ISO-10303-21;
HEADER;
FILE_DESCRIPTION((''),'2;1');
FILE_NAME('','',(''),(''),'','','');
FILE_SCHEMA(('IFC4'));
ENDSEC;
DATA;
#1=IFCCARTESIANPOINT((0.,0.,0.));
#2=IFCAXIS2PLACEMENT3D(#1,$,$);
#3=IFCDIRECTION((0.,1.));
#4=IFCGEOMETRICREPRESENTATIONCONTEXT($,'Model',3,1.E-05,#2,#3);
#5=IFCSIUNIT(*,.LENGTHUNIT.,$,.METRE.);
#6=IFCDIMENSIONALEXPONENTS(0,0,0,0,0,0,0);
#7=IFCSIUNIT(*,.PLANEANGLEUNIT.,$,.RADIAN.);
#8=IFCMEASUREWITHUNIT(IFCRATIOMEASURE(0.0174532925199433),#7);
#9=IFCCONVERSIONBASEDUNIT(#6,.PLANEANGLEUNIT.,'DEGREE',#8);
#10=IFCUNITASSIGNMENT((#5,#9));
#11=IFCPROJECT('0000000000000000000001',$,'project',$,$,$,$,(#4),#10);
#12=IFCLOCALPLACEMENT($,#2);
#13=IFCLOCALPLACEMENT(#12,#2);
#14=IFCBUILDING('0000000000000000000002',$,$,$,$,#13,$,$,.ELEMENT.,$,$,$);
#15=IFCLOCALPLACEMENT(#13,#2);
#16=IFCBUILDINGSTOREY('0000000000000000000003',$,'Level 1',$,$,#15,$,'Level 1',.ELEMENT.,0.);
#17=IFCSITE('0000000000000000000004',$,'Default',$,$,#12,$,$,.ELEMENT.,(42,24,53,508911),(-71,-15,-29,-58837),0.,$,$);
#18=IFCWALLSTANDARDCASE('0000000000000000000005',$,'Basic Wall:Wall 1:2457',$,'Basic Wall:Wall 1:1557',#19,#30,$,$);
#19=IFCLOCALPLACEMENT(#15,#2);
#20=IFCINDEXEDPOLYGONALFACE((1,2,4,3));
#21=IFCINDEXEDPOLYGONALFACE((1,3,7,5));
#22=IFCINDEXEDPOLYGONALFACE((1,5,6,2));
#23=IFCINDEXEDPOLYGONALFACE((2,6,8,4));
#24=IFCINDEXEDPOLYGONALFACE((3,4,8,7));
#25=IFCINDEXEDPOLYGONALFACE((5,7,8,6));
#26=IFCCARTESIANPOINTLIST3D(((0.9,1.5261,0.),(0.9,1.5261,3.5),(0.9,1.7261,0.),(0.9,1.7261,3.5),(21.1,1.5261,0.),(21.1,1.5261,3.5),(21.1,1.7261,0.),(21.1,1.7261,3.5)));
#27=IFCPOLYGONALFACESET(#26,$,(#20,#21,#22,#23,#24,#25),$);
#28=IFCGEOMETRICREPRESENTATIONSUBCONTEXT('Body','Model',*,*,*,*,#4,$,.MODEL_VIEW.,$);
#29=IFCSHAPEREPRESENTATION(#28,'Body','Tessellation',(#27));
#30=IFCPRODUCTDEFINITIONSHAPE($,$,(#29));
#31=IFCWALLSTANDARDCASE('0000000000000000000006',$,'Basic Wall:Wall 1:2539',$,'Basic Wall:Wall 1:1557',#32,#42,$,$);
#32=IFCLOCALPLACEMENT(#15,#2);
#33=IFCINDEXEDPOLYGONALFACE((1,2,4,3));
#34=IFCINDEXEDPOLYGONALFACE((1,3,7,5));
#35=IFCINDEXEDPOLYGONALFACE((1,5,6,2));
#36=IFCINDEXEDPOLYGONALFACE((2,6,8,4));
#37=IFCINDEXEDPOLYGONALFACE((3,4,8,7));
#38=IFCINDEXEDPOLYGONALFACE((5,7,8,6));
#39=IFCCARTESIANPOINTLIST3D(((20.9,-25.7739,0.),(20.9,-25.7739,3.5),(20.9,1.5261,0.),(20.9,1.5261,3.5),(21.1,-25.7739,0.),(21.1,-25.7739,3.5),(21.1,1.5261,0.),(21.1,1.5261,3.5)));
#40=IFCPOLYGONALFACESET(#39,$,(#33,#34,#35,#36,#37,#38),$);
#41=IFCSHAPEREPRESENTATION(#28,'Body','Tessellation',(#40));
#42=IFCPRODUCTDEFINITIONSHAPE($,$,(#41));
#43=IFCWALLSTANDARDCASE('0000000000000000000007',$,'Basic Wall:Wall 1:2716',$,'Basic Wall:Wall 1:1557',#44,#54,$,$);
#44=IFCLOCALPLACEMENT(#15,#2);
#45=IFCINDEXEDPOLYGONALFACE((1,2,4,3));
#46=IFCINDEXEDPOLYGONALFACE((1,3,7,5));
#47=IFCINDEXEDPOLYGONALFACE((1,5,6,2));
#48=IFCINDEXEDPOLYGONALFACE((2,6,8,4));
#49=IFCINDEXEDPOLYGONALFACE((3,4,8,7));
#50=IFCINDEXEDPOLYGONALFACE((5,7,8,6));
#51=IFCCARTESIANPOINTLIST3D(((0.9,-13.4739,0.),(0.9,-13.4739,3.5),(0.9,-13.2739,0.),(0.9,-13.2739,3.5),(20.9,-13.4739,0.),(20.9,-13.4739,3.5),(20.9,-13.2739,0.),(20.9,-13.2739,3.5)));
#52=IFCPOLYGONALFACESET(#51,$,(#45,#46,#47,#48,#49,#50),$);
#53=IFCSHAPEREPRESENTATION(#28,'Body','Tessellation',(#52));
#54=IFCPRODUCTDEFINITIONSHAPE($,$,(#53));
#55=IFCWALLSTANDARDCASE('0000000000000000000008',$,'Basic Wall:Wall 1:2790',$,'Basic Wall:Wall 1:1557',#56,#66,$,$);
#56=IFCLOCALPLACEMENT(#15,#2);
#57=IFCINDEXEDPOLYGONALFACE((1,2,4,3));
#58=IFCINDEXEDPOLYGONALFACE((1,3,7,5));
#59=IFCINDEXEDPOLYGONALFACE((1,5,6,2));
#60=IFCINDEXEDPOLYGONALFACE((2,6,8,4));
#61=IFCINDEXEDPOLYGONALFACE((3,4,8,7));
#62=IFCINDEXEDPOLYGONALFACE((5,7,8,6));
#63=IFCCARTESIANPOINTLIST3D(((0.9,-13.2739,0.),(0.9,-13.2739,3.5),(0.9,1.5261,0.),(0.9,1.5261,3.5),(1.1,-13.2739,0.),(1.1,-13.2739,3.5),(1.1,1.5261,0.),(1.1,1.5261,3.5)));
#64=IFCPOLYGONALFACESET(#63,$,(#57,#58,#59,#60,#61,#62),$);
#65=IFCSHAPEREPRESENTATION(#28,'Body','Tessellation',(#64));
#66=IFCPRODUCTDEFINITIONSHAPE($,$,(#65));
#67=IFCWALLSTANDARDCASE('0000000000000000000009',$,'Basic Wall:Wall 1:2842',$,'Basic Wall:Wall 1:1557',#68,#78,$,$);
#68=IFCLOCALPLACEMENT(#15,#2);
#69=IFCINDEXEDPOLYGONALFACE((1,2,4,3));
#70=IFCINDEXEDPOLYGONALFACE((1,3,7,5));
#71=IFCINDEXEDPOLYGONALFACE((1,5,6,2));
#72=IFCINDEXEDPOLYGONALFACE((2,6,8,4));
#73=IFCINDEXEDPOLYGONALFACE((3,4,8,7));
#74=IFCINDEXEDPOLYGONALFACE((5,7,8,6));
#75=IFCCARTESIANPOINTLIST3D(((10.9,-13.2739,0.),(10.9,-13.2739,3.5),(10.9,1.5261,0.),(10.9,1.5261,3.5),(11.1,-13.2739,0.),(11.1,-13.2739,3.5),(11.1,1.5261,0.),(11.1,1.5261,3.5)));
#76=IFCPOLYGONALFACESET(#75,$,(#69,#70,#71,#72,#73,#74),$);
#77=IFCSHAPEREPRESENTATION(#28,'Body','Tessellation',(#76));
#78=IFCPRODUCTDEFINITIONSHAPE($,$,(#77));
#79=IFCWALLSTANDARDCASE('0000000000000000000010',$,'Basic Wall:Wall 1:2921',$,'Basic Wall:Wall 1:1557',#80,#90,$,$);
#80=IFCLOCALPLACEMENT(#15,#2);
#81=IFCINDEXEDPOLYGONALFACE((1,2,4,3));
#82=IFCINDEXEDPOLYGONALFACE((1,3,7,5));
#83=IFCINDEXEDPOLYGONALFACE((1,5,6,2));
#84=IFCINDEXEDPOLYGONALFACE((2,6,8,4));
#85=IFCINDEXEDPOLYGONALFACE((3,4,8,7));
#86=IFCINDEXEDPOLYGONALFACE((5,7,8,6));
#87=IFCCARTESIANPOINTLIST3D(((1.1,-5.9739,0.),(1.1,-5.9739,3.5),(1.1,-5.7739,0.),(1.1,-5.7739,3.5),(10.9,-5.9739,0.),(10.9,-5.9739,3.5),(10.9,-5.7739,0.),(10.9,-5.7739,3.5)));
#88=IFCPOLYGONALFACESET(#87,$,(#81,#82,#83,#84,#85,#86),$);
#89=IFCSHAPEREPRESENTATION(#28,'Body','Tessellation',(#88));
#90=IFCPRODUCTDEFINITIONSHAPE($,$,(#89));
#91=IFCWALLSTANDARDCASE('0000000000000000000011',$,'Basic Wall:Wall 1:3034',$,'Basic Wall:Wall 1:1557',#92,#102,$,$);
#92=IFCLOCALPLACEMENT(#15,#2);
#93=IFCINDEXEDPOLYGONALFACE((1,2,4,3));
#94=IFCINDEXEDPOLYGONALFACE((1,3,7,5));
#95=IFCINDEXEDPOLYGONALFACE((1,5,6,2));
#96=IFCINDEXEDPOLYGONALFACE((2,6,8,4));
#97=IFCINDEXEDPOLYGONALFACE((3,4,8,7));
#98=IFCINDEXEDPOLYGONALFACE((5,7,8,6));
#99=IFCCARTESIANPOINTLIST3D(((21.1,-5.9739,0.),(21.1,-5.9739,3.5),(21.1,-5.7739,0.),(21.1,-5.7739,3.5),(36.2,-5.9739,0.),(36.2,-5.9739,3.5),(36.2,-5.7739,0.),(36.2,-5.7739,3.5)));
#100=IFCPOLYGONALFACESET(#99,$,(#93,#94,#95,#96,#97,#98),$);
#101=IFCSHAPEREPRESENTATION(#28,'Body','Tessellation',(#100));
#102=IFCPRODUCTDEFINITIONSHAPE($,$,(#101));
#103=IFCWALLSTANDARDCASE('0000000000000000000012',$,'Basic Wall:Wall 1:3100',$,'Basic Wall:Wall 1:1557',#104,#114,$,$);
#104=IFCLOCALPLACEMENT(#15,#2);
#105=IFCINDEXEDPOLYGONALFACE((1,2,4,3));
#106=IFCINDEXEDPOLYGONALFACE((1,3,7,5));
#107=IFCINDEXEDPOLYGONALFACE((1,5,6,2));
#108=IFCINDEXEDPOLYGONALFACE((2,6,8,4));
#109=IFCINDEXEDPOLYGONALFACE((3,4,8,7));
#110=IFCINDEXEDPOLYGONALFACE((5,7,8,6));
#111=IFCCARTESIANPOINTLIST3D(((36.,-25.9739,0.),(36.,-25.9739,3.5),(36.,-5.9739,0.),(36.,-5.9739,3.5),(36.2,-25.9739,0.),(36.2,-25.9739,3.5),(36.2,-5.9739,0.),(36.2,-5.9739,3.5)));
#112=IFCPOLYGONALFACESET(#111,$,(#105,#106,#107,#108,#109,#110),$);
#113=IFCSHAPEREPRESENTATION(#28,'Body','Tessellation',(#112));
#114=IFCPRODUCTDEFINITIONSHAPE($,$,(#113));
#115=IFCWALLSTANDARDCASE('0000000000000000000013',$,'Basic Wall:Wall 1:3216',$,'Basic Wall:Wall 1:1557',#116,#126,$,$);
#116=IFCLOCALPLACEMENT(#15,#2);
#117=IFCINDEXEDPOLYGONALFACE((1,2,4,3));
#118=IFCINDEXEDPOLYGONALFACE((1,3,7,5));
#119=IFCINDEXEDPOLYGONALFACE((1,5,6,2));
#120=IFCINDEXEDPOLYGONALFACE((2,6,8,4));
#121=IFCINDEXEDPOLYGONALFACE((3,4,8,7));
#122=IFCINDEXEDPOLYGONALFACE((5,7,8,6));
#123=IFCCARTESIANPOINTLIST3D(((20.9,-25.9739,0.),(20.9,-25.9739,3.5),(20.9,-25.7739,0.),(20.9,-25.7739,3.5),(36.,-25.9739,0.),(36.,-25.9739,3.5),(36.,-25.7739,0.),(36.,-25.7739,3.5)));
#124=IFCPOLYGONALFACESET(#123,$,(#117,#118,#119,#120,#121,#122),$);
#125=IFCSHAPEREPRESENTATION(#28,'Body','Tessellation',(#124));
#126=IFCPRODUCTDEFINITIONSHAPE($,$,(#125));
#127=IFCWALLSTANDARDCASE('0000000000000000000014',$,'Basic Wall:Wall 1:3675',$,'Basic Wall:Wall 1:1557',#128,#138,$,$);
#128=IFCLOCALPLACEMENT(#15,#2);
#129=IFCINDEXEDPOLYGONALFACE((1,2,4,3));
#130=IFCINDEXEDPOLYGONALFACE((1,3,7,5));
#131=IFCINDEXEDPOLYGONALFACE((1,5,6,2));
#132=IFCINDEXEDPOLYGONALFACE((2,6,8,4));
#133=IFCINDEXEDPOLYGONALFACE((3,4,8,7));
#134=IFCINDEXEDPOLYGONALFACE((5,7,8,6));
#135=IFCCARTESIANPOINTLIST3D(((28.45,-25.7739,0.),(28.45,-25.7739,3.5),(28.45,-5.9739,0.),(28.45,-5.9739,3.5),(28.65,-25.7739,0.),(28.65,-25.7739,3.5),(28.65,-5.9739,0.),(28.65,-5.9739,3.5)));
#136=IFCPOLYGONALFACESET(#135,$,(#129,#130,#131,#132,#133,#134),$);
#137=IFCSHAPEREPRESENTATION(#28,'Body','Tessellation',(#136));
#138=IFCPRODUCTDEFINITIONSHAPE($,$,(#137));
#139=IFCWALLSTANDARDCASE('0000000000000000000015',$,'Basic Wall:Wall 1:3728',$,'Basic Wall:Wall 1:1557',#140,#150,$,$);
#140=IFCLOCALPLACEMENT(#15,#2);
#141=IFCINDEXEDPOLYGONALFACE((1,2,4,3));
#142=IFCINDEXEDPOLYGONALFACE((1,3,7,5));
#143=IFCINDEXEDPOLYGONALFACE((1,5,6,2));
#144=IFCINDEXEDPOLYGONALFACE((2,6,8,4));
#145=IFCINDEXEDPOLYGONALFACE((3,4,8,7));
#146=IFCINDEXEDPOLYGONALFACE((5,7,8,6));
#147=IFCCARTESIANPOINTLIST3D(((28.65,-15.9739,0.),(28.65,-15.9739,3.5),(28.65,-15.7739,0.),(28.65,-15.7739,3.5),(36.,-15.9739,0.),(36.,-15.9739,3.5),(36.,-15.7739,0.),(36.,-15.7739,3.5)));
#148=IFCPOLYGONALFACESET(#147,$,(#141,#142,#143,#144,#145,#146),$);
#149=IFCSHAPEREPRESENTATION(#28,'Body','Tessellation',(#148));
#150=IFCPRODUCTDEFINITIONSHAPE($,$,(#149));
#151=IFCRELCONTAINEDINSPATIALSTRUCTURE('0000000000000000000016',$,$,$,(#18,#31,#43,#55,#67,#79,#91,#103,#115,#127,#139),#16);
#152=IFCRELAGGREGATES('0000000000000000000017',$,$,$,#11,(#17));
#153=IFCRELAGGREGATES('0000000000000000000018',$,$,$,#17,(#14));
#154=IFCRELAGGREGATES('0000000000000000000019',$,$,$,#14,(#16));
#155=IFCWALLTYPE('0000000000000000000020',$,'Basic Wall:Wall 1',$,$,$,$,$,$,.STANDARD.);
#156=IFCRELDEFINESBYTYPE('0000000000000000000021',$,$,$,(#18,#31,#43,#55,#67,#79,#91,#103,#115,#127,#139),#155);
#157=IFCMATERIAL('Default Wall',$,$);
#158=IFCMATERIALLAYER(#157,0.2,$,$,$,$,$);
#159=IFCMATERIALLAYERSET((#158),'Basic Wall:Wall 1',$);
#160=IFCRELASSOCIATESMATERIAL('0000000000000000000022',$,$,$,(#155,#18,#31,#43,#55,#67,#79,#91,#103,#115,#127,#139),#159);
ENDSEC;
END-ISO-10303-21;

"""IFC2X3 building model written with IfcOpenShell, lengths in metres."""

from ifc_helpers import new_model, entity, si_unit, converted_unit, direction, frame, frame_2d, origin, place, context, subcontext, project, spatial, rectangle, extrude, material, layer, layer_set, layer_usage, type_object, element, save


model = new_model("IFC2X3")

# Units and contexts
model_context = context("Model", 3, precision=1e-05, world=origin(), true_north=direction((0.0, 1.0)))
body_context = subcontext(model_context, "Body", "Model", "MODEL_VIEW")
ifc_project = project(units=[si_unit("LENGTHUNIT", "METRE"), converted_unit("PLANEANGLEUNIT", "DEGREE", entity("IfcRatioMeasure", 0.0174532925199433), si_unit("PLANEANGLEUNIT", "RADIAN"), dimensions=[0, 0, 0, 0, 0, 0, 0])], contexts=[model_context])

# Site, building, storey
site_placement = place(None, origin())
site = spatial("IfcSite", under=ifc_project, at=site_placement, Name="Default", CompositionType="ELEMENT", RefLatitude=(42, 24, 53, 508911), RefLongitude=(-71, -15, -29, -58837), RefElevation=0.0)
building_placement = place(site_placement, origin())
building = spatial("IfcBuilding", under=site, at=building_placement, CompositionType="ELEMENT")
storey_placement = place(building_placement, origin())
storey = spatial("IfcBuildingStorey", under=building, at=storey_placement, Name="Level 1", LongName="Level 1", CompositionType="ELEMENT", Elevation=0.0)

# Walls
ifc_material = material(Name="Default Wall")
ifc_layer = layer(ifc_material, 0.2)
ifc_layer_set = layer_set([ifc_layer], Name="Basic Wall:Wall 1")
ifc_layer_usage_1 = layer_usage(ifc_layer_set, "AXIS2", "NEGATIVE", 0.1)
wall_type = type_object("IfcWallType", Name="Basic Wall:Wall 1", PredefinedType="STANDARD", material=ifc_layer_set)
wall_1_placement = place(storey_placement, frame((0.9, 1.6261, 0.0)))
element("IfcWallStandardCase", 1, at=wall_1_placement, inside=storey, type_object=wall_type, material=ifc_layer_usage_1, Name="Basic Wall:Wall 1:2457", ObjectType="Basic Wall:Wall 1:1557", context=body_context, shape_type="SweptSolid", body=[
    extrude(rectangle(XDim=20.2, YDim=0.2, at=frame_2d((10.1, 0.0), x_axis=(-1.0, 0.0))), origin(), (0.0, 0.0, 1.0), 3.5),
])
ifc_layer_usage_2 = layer_usage(ifc_layer_set, "AXIS2", "NEGATIVE", 0.1)
wall_2_placement = place(storey_placement, frame((21.0, 1.5261, 0.0), z_axis=(0.0, 0.0, 1.0), x_axis=(0.0, -1.0, 0.0)))
element("IfcWallStandardCase", 2, at=wall_2_placement, inside=storey, type_object=wall_type, material=ifc_layer_usage_2, Name="Basic Wall:Wall 1:2539", ObjectType="Basic Wall:Wall 1:1557", context=body_context, shape_type="SweptSolid", body=[
    extrude(rectangle(XDim=27.3, YDim=0.2, at=frame_2d((13.65, 0.0), x_axis=(-1.0, 0.0))), origin(), (0.0, 0.0, 1.0), 3.5),
])
ifc_layer_usage_3 = layer_usage(ifc_layer_set, "AXIS2", "NEGATIVE", 0.1)
wall_3_placement = place(storey_placement, frame((20.9, -13.3739, 0.0), z_axis=(0.0, 0.0, 1.0), x_axis=(-1.0, 0.0, 0.0)))
element("IfcWallStandardCase", 3, at=wall_3_placement, inside=storey, type_object=wall_type, material=ifc_layer_usage_3, Name="Basic Wall:Wall 1:2716", ObjectType="Basic Wall:Wall 1:1557", context=body_context, shape_type="SweptSolid", body=[
    extrude(rectangle(XDim=20.0, YDim=0.2, at=frame_2d((10.0, 0.0), x_axis=(-1.0, 0.0))), origin(), (0.0, 0.0, 1.0), 3.5),
])
ifc_layer_usage_4 = layer_usage(ifc_layer_set, "AXIS2", "NEGATIVE", 0.1)
wall_4_placement = place(storey_placement, frame((1.0, -13.2739, 0.0), z_axis=(0.0, 0.0, 1.0), x_axis=(0.0, 1.0, 0.0)))
element("IfcWallStandardCase", 4, at=wall_4_placement, inside=storey, type_object=wall_type, material=ifc_layer_usage_4, Name="Basic Wall:Wall 1:2790", ObjectType="Basic Wall:Wall 1:1557", context=body_context, shape_type="SweptSolid", body=[
    extrude(rectangle(XDim=14.8, YDim=0.2, at=frame_2d((7.4, 0.0), x_axis=(-1.0, 0.0))), origin(), (0.0, 0.0, 1.0), 3.5),
])
ifc_layer_usage_5 = layer_usage(ifc_layer_set, "AXIS2", "NEGATIVE", 0.1)
wall_5_placement = place(storey_placement, frame((11.0, 1.5261, 0.0), z_axis=(0.0, 0.0, 1.0), x_axis=(0.0, -1.0, 0.0)))
element("IfcWallStandardCase", 5, at=wall_5_placement, inside=storey, type_object=wall_type, material=ifc_layer_usage_5, Name="Basic Wall:Wall 1:2842", ObjectType="Basic Wall:Wall 1:1557", context=body_context, shape_type="SweptSolid", body=[
    extrude(rectangle(XDim=14.8, YDim=0.2, at=frame_2d((7.4, 0.0), x_axis=(-1.0, 0.0))), origin(), (0.0, 0.0, 1.0), 3.5),
])
ifc_layer_usage_6 = layer_usage(ifc_layer_set, "AXIS2", "NEGATIVE", 0.1)
wall_6_placement = place(storey_placement, frame((10.9, -5.8739, 0.0), z_axis=(0.0, 0.0, 1.0), x_axis=(-1.0, 0.0, 0.0)))
element("IfcWallStandardCase", 6, at=wall_6_placement, inside=storey, type_object=wall_type, material=ifc_layer_usage_6, Name="Basic Wall:Wall 1:2921", ObjectType="Basic Wall:Wall 1:1557", context=body_context, shape_type="SweptSolid", body=[
    extrude(rectangle(XDim=9.8, YDim=0.2, at=frame_2d((4.9, 0.0), x_axis=(-1.0, 0.0))), origin(), (0.0, 0.0, 1.0), 3.5),
])
ifc_layer_usage_7 = layer_usage(ifc_layer_set, "AXIS2", "NEGATIVE", 0.1)
wall_7_placement = place(storey_placement, frame((21.1, -5.8739, 0.0)))
element("IfcWallStandardCase", 7, at=wall_7_placement, inside=storey, type_object=wall_type, material=ifc_layer_usage_7, Name="Basic Wall:Wall 1:3034", ObjectType="Basic Wall:Wall 1:1557", context=body_context, shape_type="SweptSolid", body=[
    extrude(rectangle(XDim=15.1, YDim=0.2, at=frame_2d((7.55, 0.0), x_axis=(-1.0, 0.0))), origin(), (0.0, 0.0, 1.0), 3.5),
])
ifc_layer_usage_8 = layer_usage(ifc_layer_set, "AXIS2", "NEGATIVE", 0.1)
wall_8_placement = place(storey_placement, frame((36.1, -5.9739, 0.0), z_axis=(0.0, 0.0, 1.0), x_axis=(0.0, -1.0, 0.0)))
element("IfcWallStandardCase", 8, at=wall_8_placement, inside=storey, type_object=wall_type, material=ifc_layer_usage_8, Name="Basic Wall:Wall 1:3100", ObjectType="Basic Wall:Wall 1:1557", context=body_context, shape_type="SweptSolid", body=[
    extrude(rectangle(XDim=20.0, YDim=0.2, at=frame_2d((10.0, 0.0), x_axis=(-1.0, 0.0))), origin(), (0.0, 0.0, 1.0), 3.5),
])
ifc_layer_usage_9 = layer_usage(ifc_layer_set, "AXIS2", "NEGATIVE", 0.1)
wall_9_placement = place(storey_placement, frame((36.0, -25.8739, 0.0), z_axis=(0.0, 0.0, 1.0), x_axis=(-1.0, 0.0, 0.0)))
element("IfcWallStandardCase", 9, at=wall_9_placement, inside=storey, type_object=wall_type, material=ifc_layer_usage_9, Name="Basic Wall:Wall 1:3216", ObjectType="Basic Wall:Wall 1:1557", context=body_context, shape_type="SweptSolid", body=[
    extrude(rectangle(XDim=15.1, YDim=0.2, at=frame_2d((7.55, 0.0), x_axis=(-1.0, 0.0))), origin(), (0.0, 0.0, 1.0), 3.5),
])
ifc_layer_usage_10 = layer_usage(ifc_layer_set, "AXIS2", "NEGATIVE", 0.1)
wall_10_placement = place(storey_placement, frame((28.55, -5.9739, 0.0), z_axis=(0.0, 0.0, 1.0), x_axis=(0.0, -1.0, 0.0)))
element("IfcWallStandardCase", 10, at=wall_10_placement, inside=storey, type_object=wall_type, material=ifc_layer_usage_10, Name="Basic Wall:Wall 1:3675", ObjectType="Basic Wall:Wall 1:1557", context=body_context, shape_type="SweptSolid", body=[
    extrude(rectangle(XDim=19.8, YDim=0.2, at=frame_2d((9.9, 0.0), x_axis=(-1.0, 0.0))), origin(), (0.0, 0.0, 1.0), 3.5),
])
ifc_layer_usage_11 = layer_usage(ifc_layer_set, "AXIS2", "NEGATIVE", 0.1)
wall_11_placement = place(storey_placement, frame((28.65, -15.8739, 0.0)))
element("IfcWallStandardCase", 11, at=wall_11_placement, inside=storey, type_object=wall_type, material=ifc_layer_usage_11, Name="Basic Wall:Wall 1:3728", ObjectType="Basic Wall:Wall 1:1557", context=body_context, shape_type="SweptSolid", body=[
    extrude(rectangle(XDim=7.35, YDim=0.2, at=frame_2d((3.675, 0.0), x_axis=(-1.0, 0.0))), origin(), (0.0, 0.0, 1.0), 3.5),
])

save(model, "model.ifc")
